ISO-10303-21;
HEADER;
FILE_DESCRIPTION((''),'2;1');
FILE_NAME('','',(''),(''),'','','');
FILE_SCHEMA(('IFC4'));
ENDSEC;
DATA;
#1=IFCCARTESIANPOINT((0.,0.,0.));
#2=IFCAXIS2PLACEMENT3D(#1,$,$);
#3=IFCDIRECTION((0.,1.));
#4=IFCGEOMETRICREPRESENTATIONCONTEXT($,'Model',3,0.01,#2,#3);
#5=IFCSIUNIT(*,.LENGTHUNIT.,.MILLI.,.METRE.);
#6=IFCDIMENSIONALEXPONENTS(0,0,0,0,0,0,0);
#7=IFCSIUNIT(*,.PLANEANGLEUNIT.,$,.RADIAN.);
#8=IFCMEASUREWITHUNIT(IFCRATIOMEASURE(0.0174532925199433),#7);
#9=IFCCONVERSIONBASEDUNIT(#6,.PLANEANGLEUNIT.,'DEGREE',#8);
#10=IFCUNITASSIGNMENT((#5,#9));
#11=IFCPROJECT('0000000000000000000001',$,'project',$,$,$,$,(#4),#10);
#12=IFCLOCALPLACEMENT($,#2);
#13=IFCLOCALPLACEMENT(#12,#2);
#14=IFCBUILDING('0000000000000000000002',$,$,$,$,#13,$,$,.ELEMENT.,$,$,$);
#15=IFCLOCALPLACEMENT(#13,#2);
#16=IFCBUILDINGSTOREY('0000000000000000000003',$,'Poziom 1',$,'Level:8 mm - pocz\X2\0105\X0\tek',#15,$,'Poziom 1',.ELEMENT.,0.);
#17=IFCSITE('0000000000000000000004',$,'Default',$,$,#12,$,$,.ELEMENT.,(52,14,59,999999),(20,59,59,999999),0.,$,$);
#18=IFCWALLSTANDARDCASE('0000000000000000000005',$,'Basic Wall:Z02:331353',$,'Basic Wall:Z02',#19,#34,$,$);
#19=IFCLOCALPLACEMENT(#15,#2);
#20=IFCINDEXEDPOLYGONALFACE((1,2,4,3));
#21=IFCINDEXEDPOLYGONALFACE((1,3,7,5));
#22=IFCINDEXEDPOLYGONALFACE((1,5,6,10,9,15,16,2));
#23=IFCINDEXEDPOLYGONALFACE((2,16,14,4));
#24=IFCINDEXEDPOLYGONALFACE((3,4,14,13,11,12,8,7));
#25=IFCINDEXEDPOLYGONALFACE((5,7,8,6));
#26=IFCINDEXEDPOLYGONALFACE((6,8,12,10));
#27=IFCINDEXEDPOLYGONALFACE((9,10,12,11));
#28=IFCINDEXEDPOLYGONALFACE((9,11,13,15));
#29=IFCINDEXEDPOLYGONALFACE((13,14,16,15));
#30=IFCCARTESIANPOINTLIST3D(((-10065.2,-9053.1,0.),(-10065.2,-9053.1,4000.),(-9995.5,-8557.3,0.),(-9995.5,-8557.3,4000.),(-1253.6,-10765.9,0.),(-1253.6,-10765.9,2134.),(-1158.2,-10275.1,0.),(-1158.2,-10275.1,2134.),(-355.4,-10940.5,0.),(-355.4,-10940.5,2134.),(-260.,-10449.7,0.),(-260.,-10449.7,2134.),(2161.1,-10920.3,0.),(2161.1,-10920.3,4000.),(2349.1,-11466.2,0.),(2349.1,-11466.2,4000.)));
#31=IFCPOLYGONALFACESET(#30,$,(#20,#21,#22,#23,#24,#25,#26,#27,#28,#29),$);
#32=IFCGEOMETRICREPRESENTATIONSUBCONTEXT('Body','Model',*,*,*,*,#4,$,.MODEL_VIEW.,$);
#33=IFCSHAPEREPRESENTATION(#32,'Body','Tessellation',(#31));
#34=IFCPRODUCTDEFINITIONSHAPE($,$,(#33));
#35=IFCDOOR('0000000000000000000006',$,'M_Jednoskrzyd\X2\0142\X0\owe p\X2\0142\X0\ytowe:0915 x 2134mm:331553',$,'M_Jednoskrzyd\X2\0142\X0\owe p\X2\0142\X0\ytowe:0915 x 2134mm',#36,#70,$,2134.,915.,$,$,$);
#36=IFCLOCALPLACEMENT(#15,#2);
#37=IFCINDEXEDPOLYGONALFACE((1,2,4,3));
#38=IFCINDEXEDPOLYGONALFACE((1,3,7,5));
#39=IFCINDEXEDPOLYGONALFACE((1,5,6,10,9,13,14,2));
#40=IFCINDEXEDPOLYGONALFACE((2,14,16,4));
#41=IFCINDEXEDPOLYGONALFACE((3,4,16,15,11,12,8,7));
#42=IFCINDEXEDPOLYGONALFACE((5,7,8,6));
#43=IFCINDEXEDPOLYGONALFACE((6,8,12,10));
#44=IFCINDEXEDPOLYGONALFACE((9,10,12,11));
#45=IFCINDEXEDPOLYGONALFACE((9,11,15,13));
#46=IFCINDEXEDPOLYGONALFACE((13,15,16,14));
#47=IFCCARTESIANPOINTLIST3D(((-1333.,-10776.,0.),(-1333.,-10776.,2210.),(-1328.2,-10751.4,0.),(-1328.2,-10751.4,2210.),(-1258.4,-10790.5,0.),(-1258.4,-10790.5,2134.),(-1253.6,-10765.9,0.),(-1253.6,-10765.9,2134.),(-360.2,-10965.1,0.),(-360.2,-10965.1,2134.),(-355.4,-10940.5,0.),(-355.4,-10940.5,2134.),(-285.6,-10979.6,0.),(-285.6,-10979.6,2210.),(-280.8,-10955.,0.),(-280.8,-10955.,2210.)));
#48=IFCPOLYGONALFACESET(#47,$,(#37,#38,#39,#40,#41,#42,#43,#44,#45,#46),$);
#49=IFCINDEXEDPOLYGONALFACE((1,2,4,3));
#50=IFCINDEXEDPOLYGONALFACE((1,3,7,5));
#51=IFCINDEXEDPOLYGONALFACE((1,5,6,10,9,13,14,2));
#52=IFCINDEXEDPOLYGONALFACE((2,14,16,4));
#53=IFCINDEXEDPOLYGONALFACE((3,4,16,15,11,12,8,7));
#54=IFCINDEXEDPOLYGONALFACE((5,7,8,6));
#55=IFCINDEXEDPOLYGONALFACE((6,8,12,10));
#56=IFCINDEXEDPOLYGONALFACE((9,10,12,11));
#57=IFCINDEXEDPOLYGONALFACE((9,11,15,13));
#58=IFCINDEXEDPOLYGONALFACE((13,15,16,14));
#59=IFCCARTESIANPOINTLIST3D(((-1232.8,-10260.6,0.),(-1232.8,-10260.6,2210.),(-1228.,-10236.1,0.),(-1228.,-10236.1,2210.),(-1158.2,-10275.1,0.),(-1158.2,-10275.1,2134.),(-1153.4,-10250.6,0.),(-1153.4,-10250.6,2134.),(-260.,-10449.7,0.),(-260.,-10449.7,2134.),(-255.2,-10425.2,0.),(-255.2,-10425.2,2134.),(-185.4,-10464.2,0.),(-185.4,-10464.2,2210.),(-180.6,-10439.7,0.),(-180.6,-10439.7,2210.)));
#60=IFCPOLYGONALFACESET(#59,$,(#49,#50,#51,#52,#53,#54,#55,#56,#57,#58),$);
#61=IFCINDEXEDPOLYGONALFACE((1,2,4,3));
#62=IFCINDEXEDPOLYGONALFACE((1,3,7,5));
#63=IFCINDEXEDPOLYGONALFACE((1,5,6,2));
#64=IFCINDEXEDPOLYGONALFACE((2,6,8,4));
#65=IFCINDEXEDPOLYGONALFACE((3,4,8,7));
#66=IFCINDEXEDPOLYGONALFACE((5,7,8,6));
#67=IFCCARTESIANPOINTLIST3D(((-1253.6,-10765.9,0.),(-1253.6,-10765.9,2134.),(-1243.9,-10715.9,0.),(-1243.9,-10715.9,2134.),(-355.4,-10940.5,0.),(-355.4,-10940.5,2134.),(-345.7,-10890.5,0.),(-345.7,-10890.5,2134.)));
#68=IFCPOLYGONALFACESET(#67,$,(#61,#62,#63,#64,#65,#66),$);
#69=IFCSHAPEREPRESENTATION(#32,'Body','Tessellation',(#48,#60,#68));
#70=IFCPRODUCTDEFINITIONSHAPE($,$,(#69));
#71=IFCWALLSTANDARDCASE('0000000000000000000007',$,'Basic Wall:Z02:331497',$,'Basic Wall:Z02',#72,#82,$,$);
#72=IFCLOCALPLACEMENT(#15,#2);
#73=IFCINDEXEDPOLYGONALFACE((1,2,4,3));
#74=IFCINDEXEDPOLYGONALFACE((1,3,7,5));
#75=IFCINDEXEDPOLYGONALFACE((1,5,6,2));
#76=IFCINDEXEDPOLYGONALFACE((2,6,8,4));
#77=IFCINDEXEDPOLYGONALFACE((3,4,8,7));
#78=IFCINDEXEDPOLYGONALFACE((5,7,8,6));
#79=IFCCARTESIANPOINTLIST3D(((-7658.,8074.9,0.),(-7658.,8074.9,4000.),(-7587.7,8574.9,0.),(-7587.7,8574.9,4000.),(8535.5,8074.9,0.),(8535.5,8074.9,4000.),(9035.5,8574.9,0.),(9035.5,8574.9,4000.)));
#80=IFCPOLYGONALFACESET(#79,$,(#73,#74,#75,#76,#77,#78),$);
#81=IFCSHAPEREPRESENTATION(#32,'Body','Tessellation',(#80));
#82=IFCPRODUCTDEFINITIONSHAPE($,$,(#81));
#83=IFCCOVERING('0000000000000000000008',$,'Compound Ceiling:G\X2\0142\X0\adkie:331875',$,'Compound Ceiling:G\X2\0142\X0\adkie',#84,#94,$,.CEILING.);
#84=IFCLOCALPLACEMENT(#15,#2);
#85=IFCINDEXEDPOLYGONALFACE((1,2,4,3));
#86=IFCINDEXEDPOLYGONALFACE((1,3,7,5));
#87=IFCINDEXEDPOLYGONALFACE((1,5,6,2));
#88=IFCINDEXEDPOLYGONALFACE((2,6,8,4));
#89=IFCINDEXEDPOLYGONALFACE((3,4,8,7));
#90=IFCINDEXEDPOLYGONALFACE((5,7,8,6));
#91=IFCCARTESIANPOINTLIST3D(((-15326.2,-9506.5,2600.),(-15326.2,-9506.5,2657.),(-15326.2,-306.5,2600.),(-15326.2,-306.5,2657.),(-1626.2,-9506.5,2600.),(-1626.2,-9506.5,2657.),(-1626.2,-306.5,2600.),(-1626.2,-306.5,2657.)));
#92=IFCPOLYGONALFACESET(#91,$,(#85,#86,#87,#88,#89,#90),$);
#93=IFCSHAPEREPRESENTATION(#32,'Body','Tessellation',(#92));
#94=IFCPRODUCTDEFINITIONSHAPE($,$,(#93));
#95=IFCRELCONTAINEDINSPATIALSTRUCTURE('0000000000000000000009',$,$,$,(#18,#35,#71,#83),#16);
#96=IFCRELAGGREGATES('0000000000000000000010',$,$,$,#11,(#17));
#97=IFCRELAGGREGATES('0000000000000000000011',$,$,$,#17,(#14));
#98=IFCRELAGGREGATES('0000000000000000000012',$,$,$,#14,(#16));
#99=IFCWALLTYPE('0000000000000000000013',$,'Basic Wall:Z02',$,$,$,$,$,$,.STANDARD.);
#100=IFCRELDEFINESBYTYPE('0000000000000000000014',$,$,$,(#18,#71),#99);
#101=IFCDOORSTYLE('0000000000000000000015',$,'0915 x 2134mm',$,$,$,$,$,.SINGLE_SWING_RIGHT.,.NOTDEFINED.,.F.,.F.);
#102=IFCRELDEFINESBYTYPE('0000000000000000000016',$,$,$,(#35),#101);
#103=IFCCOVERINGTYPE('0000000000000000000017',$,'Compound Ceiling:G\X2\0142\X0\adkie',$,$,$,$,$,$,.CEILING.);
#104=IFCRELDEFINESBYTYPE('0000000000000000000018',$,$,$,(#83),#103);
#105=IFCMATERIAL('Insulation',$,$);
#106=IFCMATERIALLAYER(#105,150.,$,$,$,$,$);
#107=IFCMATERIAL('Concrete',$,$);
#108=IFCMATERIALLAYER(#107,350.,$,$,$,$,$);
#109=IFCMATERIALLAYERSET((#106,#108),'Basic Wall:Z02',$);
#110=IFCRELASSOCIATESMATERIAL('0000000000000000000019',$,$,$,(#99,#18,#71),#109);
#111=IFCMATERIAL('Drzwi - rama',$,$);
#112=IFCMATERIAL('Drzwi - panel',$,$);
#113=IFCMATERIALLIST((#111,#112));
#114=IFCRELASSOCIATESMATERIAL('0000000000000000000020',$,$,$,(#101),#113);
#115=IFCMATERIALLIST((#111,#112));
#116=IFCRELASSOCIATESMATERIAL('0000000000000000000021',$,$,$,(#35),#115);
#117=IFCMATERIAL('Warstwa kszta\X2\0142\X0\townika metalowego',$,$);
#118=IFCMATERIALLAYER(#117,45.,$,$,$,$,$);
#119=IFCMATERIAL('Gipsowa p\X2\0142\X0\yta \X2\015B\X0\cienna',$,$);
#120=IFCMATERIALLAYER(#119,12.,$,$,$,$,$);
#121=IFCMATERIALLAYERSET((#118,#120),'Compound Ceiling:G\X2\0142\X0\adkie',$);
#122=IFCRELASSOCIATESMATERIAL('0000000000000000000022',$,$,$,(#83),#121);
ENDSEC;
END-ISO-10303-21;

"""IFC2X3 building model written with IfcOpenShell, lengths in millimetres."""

from ifc_helpers import new_model, entity, si_unit, converted_unit, direction, frame, frame_2d, origin, origin_2d_with_axis, place, context, subcontext, project, spatial, polyline, rectangle, outline, extrude, clip, halfspace, source, transform, mapped, material, material_list, layer, layer_set, layer_usage, type_object, type_shapes, element, fill, save


model = new_model("IFC2X3")

# Units and contexts
model_context = context("Model", 3, precision=0.01, world=origin(), true_north=direction((0.0, 1.0)))
body_context = subcontext(model_context, "Body", "Model", "MODEL_VIEW")
ifc_project = project(units=[si_unit("LENGTHUNIT", "METRE", prefix="MILLI"), converted_unit("PLANEANGLEUNIT", "DEGREE", entity("IfcRatioMeasure", 0.0174532925199433), si_unit("PLANEANGLEUNIT", "RADIAN"), dimensions=[0, 0, 0, 0, 0, 0, 0])], contexts=[model_context])

# Site, building, storey
site_placement = place(None, origin())
site = spatial("IfcSite", under=ifc_project, at=site_placement, Name="Default", CompositionType="ELEMENT", RefLatitude=(52, 14, 59, 999999), RefLongitude=(20, 59, 59, 999999), RefElevation=0.0)
building_placement = place(site_placement, origin())
building = spatial("IfcBuilding", under=site, at=building_placement, CompositionType="ELEMENT")
storey_placement = place(building_placement, origin())
storey = spatial("IfcBuildingStorey", under=building, at=storey_placement, Name="Poziom 1", ObjectType="Level:8 mm - początek", LongName="Poziom 1", CompositionType="ELEMENT", Elevation=0.0)

# Wall, opening, door
ifc_material_1 = material(Name="Insulation")
ifc_layer_1 = layer(ifc_material_1, 150.0)
ifc_material_2 = material(Name="Concrete")
ifc_layer_2 = layer(ifc_material_2, 350.0)
ifc_layer_set_1 = layer_set([ifc_layer_1, ifc_layer_2], Name="Basic Wall:Z02")
ifc_layer_usage_1 = layer_usage(ifc_layer_set_1, "AXIS2", "NEGATIVE", 250.0)
wall_type_1 = type_object("IfcWallType", Name="Basic Wall:Z02", PredefinedType="STANDARD", material=ifc_layer_set_1)
wall_1_placement = place(storey_placement, frame((-10043.2, -8802.7, 0.0), z_axis=(0.0, 0.0, 1.0), x_axis=(0.981627, -0.190809, 0.0)))
wall_1 = element("IfcWallStandardCase", 1, at=wall_1_placement, inside=storey, type_object=wall_type_1, material=ifc_layer_usage_1, Name="Basic Wall:Z02:331353", ObjectType="Basic Wall:Z02", context=body_context, shape_type="Clipping", body=[
    clip(extrude(outline(polyline([(26.2, -250.0), (12672.8, -250.0), (12384.1, 250.0), (12153.2, 250.0), (0.0, 250.0), (26.2, -250.0)])), origin(), (0.0, 0.0, 1.0), 4000.0), halfspace(origin(), True)),
])
opening_1_placement = place(wall_1_placement, frame((9917.7, 250.0, 0.0)))
opening_1 = element("IfcOpeningElement", 2, at=opening_1_placement, cuts=wall_1, ObjectType="Opening", context=body_context, shape_type="SweptSolid", body=[
    extrude(rectangle(XDim=915.0, YDim=2134.0, at=frame_2d((1067.0, 457.5), x_axis=(0.0, 1.0))), frame((0.0, 0.0, 0.0), z_axis=(0.0, -1.0, 0.0), x_axis=(0.0, 0.0, 1.0)), (0.0, 0.0, 1.0), 500.0),
])
ifc_material_3 = material(Name="Drzwi - rama")
ifc_material_4 = material(Name="Drzwi - panel")
ifc_material_list_1 = material_list([ifc_material_3, ifc_material_4])
ifc_material_list_2 = material_list([ifc_material_3, ifc_material_4])
door_style = type_object("IfcDoorStyle", Name="0915 x 2134mm", ConstructionType="NOTDEFINED", OperationType="SINGLE_SWING_RIGHT", ParameterTakesPrecedence=False, Sizeable=False, material=ifc_material_list_2)
shared_shape_1 = source(origin(), body_context, "Body", "SweptSolid", [
    extrude(outline(polyline([(-533.5, -1124.0), (533.5, -1124.0), (533.5, 1086.0), (457.5, 1086.0), (457.5, -1048.0), (-457.5, -1048.0), (-457.5, 1086.0), (-533.5, 1086.0), (-533.5, -1124.0)])), frame((457.5, 500.0, 1086.0), z_axis=(0.0, 1.0, 0.0), x_axis=(1.0, 0.0, 0.0)), (0.0, 0.0, 1.0), 25.0),
    extrude(outline(polyline([(-1124.0, -533.5), (1086.0, -533.5), (1086.0, -457.5), (-1048.0, -457.5), (-1048.0, 457.5), (1086.0, 457.5), (1086.0, 533.5), (-1124.0, 533.5), (-1124.0, -533.5)])), frame((457.5, -25.0, 1086.0), z_axis=(0.0, 1.0, 0.0), x_axis=(0.0, 0.0, -1.0)), (0.0, 0.0, 1.0), 25.0),
    extrude(rectangle(XDim=51.0, YDim=915.0, at=frame_2d((0.0, 0.0), x_axis=(1.0, 0.0))), frame((457.5, 474.5, 0.0), z_axis=(0.0, 0.0, 1.0), x_axis=(0.0, 1.0, 0.0)), (0.0, 0.0, 1.0), 2134.0),
])
type_shapes(door_style, [shared_shape_1])
door_placement = place(opening_1_placement, frame((0.0, 0.0, 0.0), z_axis=(0.0, 0.0, 1.0), x_axis=(-1.0, 0.0, 0.0)))
door = element("IfcDoor", 3, at=door_placement, inside=storey, type_object=door_style, material=ifc_material_list_1, Name="M_Jednoskrzydłowe płytowe:0915 x 2134mm:331553", ObjectType="M_Jednoskrzydłowe płytowe:0915 x 2134mm", OverallHeight=2134.0, OverallWidth=915.0, context=body_context, shape_type="MappedRepresentation", body=[
    mapped(shared_shape_1, transform((0.0, 0.0, 0.0), scale=1.0)),
])
fill(opening_1, door)

# Wall
ifc_layer_usage_2 = layer_usage(ifc_layer_set_1, "AXIS2", "NEGATIVE", 250.0)
wall_2_placement = place(storey_placement, frame((9035.5, 8324.9, 0.0), z_axis=(0.0, 0.0, 1.0), x_axis=(-1.0, 0.0, 0.0)))
element("IfcWallStandardCase", 4, at=wall_2_placement, inside=storey, type_object=wall_type_1, material=ifc_layer_usage_2, Name="Basic Wall:Z02:331497", ObjectType="Basic Wall:Z02", context=body_context, shape_type="Clipping", body=[
    clip(extrude(outline(polyline([(16623.2, -250.0), (16693.5, 250.0), (500.0, 250.0), (0.0, -250.0), (16623.2, -250.0)])), origin(), (0.0, 0.0, 1.0), 4000.0), halfspace(origin(), True)),
])

# Covering
ifc_material_5 = material(Name="Warstwa kształtownika metalowego")
ifc_layer_3 = layer(ifc_material_5, 45.0)
ifc_material_6 = material(Name="Gipsowa płyta ścienna")
ifc_layer_4 = layer(ifc_material_6, 12.0)
ifc_layer_set_2 = layer_set([ifc_layer_3, ifc_layer_4], Name="Compound Ceiling:Gładkie")
ifc_layer_usage_3 = layer_usage(ifc_layer_set_2, "AXIS3", "POSITIVE", 0.0)
covering_type = type_object("IfcCoveringType", Name="Compound Ceiling:Gładkie", PredefinedType="CEILING")
covering_placement = place(storey_placement, origin())
element("IfcCovering", 5, at=covering_placement, inside=storey, type_object=covering_type, material=ifc_layer_usage_3, Name="Compound Ceiling:Gładkie:331875", ObjectType="Compound Ceiling:Gładkie", PredefinedType="CEILING", context=body_context, shape_type="SweptSolid", body=[
    extrude(rectangle(XDim=13700.0, YDim=9200.0, at=origin_2d_with_axis()), frame((-8476.2, -4906.5, 2600.0), z_axis=(0.0, 0.0, 1.0), x_axis=(-1.0, 0.0, 0.0)), (0.0, 0.0, 1.0), 57.0),
])

save(model, "model.ifc")
